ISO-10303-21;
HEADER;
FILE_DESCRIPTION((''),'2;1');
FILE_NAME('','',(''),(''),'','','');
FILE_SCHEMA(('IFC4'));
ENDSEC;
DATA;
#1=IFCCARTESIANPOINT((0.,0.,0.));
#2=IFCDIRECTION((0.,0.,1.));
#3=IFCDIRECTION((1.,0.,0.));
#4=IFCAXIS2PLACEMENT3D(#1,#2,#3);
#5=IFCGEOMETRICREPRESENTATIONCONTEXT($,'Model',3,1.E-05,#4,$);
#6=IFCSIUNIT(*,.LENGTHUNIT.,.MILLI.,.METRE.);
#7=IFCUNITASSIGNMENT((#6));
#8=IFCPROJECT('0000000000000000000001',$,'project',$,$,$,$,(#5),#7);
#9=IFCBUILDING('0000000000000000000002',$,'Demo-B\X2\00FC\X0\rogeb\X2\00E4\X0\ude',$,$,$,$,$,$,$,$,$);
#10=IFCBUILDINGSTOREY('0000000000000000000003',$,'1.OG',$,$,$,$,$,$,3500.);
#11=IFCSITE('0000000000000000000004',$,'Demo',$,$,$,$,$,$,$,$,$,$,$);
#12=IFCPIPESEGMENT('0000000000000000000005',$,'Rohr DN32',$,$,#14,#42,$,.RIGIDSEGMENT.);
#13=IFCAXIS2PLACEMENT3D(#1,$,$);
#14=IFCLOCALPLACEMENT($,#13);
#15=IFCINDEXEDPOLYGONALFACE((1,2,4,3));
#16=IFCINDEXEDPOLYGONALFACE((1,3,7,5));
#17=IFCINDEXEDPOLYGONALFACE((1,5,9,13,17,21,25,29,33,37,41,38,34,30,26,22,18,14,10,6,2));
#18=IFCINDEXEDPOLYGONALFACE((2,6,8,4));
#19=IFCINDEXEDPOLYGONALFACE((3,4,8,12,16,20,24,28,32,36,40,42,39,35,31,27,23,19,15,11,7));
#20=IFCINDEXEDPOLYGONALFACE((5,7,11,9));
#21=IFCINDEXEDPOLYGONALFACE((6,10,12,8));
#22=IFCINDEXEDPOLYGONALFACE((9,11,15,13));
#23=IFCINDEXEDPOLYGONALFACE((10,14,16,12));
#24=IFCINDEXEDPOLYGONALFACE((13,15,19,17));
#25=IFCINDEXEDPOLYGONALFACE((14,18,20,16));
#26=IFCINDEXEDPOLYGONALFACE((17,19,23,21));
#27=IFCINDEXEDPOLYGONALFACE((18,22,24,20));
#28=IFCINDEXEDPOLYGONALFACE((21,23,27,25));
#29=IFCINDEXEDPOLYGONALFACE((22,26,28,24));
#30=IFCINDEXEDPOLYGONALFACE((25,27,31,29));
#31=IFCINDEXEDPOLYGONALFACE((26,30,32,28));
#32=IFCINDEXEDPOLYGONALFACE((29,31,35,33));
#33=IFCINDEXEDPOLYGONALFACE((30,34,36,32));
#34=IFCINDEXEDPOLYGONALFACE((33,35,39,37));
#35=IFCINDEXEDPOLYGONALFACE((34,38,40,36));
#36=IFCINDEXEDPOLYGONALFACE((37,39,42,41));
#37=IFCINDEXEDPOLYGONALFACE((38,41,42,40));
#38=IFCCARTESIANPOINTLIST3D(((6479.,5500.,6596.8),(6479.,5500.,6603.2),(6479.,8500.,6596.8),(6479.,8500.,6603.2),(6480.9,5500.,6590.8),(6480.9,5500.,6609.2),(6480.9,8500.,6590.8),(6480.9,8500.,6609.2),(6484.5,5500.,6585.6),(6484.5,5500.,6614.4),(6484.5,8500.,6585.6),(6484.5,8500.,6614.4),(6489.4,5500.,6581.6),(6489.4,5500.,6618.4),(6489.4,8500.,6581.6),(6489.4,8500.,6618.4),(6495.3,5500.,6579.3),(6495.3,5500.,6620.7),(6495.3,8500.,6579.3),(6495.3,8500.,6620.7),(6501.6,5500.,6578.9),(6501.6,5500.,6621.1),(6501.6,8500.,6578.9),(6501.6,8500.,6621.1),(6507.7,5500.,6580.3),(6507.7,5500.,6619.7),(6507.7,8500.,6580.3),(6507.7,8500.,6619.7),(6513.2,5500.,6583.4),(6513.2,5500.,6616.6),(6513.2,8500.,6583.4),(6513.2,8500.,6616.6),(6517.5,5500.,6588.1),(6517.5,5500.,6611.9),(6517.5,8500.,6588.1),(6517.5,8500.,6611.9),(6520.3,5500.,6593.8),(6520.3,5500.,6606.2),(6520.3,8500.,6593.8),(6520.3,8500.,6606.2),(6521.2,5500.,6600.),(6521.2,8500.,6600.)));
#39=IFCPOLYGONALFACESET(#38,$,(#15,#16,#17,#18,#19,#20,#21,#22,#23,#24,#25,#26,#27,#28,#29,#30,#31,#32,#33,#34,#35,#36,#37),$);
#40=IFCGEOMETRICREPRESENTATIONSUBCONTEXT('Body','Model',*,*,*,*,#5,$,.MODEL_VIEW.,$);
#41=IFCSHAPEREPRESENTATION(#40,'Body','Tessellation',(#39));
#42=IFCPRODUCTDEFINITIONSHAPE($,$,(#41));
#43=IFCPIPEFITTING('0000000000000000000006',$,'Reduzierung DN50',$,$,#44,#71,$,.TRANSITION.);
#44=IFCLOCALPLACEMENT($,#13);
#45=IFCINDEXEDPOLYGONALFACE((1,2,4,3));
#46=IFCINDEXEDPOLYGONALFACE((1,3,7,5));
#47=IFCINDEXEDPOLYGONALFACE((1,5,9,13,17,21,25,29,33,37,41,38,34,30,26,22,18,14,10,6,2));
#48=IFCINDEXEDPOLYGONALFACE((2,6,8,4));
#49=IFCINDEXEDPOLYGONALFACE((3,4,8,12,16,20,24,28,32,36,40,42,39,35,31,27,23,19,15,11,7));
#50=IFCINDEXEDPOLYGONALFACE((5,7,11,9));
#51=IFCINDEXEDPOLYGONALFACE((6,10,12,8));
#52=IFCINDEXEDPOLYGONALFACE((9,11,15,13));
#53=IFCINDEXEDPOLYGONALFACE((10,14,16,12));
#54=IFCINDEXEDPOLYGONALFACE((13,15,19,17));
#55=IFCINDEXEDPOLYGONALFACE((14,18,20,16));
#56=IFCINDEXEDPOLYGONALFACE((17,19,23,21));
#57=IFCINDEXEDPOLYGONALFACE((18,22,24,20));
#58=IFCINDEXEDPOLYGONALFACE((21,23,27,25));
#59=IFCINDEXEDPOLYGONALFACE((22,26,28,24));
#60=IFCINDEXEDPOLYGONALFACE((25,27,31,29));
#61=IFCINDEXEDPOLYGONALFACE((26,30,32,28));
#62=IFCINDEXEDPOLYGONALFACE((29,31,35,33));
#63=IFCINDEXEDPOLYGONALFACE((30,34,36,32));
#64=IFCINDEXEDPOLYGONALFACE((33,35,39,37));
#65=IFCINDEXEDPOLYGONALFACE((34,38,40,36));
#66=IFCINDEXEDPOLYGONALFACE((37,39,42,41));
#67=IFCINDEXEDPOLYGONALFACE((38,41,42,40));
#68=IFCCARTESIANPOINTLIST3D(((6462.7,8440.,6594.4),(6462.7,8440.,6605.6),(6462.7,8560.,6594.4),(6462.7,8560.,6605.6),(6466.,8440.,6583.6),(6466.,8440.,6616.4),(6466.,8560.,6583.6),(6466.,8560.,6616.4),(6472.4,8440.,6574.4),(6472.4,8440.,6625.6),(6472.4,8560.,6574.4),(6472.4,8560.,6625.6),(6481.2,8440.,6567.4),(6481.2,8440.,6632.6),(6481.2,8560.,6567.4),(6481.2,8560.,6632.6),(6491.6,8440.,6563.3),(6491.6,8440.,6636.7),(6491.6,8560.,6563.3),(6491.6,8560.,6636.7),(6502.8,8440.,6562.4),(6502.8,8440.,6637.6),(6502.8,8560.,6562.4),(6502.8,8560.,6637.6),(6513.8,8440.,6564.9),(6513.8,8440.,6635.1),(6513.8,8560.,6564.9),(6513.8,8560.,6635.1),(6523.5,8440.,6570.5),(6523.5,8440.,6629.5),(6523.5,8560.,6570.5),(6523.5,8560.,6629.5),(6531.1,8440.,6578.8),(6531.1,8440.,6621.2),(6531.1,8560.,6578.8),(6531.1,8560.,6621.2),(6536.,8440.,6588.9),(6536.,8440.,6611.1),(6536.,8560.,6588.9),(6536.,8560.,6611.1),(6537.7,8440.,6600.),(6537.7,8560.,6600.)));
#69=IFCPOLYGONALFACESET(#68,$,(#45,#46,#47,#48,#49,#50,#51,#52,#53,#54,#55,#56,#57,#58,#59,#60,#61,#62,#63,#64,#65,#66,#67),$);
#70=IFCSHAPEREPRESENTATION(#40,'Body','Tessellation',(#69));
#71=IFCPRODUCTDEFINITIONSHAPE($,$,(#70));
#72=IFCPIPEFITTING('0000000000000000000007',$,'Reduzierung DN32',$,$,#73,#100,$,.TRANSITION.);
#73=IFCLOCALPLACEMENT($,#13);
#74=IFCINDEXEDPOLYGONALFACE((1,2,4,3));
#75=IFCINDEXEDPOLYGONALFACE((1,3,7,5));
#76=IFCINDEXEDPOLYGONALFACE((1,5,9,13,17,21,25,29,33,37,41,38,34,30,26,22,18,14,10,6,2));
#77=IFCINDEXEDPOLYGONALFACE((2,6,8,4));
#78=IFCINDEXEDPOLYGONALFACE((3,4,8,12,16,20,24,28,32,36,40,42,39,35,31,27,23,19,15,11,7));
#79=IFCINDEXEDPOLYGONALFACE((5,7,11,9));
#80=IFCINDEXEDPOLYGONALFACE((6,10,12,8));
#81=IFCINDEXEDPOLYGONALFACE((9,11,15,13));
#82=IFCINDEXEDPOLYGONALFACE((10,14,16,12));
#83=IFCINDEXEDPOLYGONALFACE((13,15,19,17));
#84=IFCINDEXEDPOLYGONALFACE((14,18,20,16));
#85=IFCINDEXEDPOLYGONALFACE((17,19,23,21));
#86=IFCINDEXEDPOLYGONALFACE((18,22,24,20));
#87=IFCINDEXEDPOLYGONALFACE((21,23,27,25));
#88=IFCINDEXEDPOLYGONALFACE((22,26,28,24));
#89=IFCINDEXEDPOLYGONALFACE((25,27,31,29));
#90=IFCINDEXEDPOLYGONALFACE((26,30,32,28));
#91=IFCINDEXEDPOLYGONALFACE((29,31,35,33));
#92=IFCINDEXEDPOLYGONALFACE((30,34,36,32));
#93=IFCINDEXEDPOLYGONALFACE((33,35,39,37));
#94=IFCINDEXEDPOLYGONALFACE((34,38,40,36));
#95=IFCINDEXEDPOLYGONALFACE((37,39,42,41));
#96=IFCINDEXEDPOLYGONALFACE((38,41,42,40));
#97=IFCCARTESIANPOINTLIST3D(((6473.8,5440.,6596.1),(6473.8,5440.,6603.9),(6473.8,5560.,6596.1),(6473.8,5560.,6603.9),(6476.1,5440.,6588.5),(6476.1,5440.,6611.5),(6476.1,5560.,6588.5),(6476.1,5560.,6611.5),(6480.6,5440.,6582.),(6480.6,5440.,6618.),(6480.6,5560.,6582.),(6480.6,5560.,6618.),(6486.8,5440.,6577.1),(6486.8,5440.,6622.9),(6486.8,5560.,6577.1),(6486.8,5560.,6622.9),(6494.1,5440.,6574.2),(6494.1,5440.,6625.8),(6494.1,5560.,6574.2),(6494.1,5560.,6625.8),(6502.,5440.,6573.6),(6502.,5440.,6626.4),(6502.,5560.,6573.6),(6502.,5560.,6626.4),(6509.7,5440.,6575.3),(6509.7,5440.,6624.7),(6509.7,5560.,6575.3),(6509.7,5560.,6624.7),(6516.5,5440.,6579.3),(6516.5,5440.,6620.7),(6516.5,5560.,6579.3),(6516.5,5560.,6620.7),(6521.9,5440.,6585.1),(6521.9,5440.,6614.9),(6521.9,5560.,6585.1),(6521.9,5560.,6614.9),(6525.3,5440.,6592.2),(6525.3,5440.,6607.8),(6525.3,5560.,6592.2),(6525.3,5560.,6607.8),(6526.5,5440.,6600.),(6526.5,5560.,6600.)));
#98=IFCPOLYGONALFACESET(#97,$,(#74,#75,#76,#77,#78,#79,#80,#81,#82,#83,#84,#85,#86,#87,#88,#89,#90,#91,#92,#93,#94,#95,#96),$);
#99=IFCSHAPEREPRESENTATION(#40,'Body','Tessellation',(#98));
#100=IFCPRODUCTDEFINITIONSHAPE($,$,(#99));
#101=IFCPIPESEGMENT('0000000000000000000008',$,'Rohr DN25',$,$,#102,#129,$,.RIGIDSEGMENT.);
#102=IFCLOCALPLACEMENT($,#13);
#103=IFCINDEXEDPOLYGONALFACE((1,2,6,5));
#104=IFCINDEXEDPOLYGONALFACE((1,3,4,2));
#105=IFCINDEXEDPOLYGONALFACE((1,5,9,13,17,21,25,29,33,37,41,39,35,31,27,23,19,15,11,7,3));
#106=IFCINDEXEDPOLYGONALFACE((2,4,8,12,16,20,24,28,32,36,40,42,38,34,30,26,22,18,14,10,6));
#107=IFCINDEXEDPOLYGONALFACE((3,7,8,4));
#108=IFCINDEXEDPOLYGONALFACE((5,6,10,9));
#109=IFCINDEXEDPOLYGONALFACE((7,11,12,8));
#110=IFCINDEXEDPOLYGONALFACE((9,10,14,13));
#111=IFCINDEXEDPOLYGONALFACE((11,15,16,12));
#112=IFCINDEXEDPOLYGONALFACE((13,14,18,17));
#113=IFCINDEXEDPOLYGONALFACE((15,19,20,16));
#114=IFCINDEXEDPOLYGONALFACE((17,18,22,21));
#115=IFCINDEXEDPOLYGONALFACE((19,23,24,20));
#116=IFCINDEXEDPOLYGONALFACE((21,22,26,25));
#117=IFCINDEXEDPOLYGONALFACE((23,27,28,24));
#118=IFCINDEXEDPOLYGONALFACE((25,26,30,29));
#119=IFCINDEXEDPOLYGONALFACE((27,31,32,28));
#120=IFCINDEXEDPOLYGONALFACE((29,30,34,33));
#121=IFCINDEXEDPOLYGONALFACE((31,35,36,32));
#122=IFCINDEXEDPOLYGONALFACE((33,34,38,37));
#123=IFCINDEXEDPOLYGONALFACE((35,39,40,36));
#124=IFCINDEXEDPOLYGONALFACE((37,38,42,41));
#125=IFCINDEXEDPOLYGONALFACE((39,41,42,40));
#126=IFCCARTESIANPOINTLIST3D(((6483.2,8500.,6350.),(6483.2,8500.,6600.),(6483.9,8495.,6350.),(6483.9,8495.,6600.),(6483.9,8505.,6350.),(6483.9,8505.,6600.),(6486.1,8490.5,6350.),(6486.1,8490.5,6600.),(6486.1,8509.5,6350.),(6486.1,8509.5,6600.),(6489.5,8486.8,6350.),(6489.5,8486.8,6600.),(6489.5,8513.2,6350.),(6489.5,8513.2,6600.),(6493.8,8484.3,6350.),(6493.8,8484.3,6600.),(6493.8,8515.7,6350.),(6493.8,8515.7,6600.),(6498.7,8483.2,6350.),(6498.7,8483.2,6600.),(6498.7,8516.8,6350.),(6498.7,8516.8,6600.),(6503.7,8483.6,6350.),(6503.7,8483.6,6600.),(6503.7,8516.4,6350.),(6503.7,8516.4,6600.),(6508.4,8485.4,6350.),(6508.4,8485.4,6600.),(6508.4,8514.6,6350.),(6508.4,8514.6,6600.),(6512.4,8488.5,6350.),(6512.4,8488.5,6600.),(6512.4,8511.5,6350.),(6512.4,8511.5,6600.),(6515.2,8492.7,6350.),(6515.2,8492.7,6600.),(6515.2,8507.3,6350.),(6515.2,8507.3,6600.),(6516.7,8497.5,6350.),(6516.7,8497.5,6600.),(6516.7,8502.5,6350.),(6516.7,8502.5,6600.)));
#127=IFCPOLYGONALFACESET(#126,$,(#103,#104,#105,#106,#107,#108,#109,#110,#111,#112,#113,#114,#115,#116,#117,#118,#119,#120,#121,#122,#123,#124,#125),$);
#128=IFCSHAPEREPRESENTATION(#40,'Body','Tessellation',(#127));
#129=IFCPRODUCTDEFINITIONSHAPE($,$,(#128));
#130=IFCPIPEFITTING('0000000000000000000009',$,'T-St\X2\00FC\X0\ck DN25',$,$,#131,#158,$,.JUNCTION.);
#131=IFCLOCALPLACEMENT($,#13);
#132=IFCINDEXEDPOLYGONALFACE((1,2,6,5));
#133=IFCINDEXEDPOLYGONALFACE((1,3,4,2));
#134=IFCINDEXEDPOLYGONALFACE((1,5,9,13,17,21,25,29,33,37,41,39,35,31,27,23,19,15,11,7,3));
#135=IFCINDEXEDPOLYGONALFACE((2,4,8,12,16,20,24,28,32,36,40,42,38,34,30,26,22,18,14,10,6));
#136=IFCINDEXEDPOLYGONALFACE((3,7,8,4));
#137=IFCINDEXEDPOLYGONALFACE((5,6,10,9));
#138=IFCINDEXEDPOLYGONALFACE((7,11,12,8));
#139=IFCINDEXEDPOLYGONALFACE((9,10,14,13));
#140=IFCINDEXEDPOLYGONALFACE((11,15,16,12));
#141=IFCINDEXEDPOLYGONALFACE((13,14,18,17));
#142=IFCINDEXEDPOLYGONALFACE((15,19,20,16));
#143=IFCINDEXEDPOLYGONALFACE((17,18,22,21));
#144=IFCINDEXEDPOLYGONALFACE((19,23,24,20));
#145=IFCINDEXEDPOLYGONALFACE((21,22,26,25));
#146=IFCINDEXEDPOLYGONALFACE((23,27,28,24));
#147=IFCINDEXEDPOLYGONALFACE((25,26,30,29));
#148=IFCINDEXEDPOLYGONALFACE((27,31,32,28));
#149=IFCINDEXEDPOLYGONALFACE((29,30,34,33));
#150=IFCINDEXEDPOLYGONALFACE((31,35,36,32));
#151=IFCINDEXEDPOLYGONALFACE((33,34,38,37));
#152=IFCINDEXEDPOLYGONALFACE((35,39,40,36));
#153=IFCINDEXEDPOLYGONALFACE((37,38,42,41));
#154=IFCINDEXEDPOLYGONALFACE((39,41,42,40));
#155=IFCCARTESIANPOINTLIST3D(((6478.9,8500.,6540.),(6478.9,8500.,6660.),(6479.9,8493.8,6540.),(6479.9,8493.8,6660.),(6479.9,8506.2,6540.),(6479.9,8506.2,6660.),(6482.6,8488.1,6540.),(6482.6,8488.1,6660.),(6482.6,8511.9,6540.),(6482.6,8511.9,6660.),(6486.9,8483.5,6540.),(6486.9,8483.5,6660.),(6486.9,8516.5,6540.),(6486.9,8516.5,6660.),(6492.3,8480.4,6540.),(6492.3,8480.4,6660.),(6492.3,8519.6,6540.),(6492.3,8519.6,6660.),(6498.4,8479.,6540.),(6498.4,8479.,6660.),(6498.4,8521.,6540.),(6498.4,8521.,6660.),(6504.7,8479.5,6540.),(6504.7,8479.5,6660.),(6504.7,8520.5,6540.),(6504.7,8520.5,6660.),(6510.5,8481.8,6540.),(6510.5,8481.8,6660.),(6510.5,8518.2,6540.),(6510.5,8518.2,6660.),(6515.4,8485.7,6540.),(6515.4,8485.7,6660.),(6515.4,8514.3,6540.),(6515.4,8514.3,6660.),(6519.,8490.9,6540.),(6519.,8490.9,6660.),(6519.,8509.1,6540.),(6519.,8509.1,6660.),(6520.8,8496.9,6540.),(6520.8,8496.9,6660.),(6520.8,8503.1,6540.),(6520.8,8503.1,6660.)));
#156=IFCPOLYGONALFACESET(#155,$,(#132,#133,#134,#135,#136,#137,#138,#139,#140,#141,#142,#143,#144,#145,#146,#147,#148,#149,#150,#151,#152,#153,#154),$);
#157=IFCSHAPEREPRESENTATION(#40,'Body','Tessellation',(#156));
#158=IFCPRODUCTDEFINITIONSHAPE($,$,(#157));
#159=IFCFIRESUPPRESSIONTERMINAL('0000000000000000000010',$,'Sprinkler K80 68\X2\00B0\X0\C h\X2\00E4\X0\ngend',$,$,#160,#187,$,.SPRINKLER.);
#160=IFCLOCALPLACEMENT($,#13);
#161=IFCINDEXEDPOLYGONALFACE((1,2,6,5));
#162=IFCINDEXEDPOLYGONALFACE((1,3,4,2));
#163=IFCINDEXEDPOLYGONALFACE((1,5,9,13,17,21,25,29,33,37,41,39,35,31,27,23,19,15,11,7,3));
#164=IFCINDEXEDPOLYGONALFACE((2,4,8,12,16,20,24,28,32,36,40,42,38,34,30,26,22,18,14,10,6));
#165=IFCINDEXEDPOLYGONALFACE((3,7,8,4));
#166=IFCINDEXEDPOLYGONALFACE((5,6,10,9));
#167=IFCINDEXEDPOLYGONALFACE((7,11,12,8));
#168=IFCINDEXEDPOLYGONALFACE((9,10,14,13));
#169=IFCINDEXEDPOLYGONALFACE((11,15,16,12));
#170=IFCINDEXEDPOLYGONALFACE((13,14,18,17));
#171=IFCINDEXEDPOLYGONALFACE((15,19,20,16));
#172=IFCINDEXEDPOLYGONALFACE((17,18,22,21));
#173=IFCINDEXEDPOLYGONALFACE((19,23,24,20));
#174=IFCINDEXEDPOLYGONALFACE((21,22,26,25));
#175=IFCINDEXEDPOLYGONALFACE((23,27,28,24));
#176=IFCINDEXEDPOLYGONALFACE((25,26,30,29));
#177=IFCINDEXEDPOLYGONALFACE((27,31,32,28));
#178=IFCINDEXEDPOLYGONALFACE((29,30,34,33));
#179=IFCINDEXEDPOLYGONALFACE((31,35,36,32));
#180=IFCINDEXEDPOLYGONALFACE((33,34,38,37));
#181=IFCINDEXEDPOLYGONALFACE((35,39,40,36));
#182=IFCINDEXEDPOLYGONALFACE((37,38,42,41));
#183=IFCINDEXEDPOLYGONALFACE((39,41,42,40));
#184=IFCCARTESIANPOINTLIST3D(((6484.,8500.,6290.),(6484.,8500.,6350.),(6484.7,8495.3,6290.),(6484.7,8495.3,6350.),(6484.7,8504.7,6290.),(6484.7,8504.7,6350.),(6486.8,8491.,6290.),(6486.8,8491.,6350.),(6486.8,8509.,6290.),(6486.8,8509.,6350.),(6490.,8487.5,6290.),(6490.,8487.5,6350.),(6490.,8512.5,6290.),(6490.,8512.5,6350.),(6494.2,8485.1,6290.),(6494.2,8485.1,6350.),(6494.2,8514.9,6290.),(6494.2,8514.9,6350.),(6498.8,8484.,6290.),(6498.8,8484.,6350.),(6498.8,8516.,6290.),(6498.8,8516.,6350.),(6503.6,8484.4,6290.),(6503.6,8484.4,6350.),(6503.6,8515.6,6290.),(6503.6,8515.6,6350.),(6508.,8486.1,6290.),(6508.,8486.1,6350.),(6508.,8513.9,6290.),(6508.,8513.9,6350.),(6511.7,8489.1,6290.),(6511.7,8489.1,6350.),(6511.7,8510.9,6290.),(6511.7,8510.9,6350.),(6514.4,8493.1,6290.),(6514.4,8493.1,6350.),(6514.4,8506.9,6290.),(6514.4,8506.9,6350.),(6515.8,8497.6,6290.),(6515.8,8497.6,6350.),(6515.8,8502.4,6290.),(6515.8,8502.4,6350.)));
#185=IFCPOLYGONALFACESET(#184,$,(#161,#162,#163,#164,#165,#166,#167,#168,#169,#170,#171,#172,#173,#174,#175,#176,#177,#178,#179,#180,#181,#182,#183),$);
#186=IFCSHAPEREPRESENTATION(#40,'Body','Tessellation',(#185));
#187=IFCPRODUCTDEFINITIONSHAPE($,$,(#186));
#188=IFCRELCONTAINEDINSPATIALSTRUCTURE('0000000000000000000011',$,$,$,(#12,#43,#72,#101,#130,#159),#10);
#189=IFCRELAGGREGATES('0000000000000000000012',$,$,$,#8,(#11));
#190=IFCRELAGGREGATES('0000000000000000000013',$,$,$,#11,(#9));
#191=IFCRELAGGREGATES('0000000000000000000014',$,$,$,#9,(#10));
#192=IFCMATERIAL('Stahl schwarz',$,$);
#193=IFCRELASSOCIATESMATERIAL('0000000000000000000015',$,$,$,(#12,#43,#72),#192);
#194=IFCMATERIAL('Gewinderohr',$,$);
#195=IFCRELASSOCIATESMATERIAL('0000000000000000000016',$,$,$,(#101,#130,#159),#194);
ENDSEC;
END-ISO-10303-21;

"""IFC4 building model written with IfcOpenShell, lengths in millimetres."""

from ifc_helpers import new_model, si_unit, frame, origin_with_axes, place, context, subcontext, project, spatial, circle, extrude, material, element, save


model = new_model("IFC4")

# Units and contexts
model_context = context("Model", 3, precision=1e-05, world=origin_with_axes())
body_context = subcontext(model_context, "Body", "Model", "MODEL_VIEW")
ifc_project = project(units=[si_unit("LENGTHUNIT", "METRE", prefix="MILLI")], contexts=[model_context])

# Site, building, storey
site = spatial("IfcSite", under=ifc_project, Name="Demo")
building = spatial("IfcBuilding", under=site, Name="Demo-Bürogebäude")
storey = spatial("IfcBuildingStorey", under=building, Name="1.OG", Elevation=3500.0)

# Pipe segment
ifc_material_1 = material(Name="Stahl schwarz")
pipe_segment_1_placement = place(None, frame((6500.0, 8500.0, 6600.0), z_axis=(0.0, -1.0, 0.0), x_axis=(1.0, 0.0, 0.0)))
element("IfcPipeSegment", 1, at=pipe_segment_1_placement, inside=storey, material=ifc_material_1, Name="Rohr DN32", PredefinedType="RIGIDSEGMENT", context=body_context, shape_type="SweptSolid", body=[
    extrude(circle(Radius=21.2), origin_with_axes(), (0.0, 0.0, 1.0), 3000.0),
])

# Pipe fittings
pipe_fitting_1_placement = place(None, frame((6500.0, 8560.0, 6600.0), z_axis=(0.0, -1.0, 0.0), x_axis=(1.0, 0.0, 0.0)))
element("IfcPipeFitting", 2, at=pipe_fitting_1_placement, inside=storey, material=ifc_material_1, Name="Reduzierung DN50", PredefinedType="TRANSITION", context=body_context, shape_type="SweptSolid", body=[
    extrude(circle(Radius=37.7), origin_with_axes(), (0.0, 0.0, 1.0), 120.0),
])
pipe_fitting_2_placement = place(None, frame((6500.0, 5560.0, 6600.0), z_axis=(0.0, -1.0, 0.0), x_axis=(1.0, 0.0, 0.0)))
element("IfcPipeFitting", 3, at=pipe_fitting_2_placement, inside=storey, material=ifc_material_1, Name="Reduzierung DN32", PredefinedType="TRANSITION", context=body_context, shape_type="SweptSolid", body=[
    extrude(circle(Radius=26.5), origin_with_axes(), (0.0, 0.0, 1.0), 120.0),
])

# Pipe segment
ifc_material_2 = material(Name="Gewinderohr")
pipe_segment_2_placement = place(None, frame((6500.0, 8500.0, 6600.0), z_axis=(0.0, 0.0, -1.0), x_axis=(-1.0, 0.0, 0.0)))
element("IfcPipeSegment", 4, at=pipe_segment_2_placement, inside=storey, material=ifc_material_2, Name="Rohr DN25", PredefinedType="RIGIDSEGMENT", context=body_context, shape_type="SweptSolid", body=[
    extrude(circle(Radius=16.9), origin_with_axes(), (0.0, 0.0, 1.0), 250.0),
])

# Pipe fitting
pipe_fitting_3_placement = place(None, frame((6500.0, 8500.0, 6660.0), z_axis=(0.0, 0.0, -1.0), x_axis=(-1.0, 0.0, 0.0)))
element("IfcPipeFitting", 5, at=pipe_fitting_3_placement, inside=storey, material=ifc_material_2, Name="T-Stück DN25", PredefinedType="JUNCTION", context=body_context, shape_type="SweptSolid", body=[
    extrude(circle(Radius=21.1), origin_with_axes(), (0.0, 0.0, 1.0), 120.0),
])

# Fire suppression terminal
fire_suppression_terminal_1_placement = place(None, frame((6500.0, 8500.0, 6350.0), z_axis=(0.0, 0.0, -1.0), x_axis=(-1.0, 0.0, 0.0)))
element("IfcFireSuppressionTerminal", 6, at=fire_suppression_terminal_1_placement, inside=storey, material=ifc_material_2, Name="Sprinkler K80 68°C hängend", PredefinedType="SPRINKLER", context=body_context, shape_type="SweptSolid", body=[
    extrude(circle(Radius=16.0), origin_with_axes(), (0.0, 0.0, 1.0), 60.0),
])

save(model, "model.ifc")
